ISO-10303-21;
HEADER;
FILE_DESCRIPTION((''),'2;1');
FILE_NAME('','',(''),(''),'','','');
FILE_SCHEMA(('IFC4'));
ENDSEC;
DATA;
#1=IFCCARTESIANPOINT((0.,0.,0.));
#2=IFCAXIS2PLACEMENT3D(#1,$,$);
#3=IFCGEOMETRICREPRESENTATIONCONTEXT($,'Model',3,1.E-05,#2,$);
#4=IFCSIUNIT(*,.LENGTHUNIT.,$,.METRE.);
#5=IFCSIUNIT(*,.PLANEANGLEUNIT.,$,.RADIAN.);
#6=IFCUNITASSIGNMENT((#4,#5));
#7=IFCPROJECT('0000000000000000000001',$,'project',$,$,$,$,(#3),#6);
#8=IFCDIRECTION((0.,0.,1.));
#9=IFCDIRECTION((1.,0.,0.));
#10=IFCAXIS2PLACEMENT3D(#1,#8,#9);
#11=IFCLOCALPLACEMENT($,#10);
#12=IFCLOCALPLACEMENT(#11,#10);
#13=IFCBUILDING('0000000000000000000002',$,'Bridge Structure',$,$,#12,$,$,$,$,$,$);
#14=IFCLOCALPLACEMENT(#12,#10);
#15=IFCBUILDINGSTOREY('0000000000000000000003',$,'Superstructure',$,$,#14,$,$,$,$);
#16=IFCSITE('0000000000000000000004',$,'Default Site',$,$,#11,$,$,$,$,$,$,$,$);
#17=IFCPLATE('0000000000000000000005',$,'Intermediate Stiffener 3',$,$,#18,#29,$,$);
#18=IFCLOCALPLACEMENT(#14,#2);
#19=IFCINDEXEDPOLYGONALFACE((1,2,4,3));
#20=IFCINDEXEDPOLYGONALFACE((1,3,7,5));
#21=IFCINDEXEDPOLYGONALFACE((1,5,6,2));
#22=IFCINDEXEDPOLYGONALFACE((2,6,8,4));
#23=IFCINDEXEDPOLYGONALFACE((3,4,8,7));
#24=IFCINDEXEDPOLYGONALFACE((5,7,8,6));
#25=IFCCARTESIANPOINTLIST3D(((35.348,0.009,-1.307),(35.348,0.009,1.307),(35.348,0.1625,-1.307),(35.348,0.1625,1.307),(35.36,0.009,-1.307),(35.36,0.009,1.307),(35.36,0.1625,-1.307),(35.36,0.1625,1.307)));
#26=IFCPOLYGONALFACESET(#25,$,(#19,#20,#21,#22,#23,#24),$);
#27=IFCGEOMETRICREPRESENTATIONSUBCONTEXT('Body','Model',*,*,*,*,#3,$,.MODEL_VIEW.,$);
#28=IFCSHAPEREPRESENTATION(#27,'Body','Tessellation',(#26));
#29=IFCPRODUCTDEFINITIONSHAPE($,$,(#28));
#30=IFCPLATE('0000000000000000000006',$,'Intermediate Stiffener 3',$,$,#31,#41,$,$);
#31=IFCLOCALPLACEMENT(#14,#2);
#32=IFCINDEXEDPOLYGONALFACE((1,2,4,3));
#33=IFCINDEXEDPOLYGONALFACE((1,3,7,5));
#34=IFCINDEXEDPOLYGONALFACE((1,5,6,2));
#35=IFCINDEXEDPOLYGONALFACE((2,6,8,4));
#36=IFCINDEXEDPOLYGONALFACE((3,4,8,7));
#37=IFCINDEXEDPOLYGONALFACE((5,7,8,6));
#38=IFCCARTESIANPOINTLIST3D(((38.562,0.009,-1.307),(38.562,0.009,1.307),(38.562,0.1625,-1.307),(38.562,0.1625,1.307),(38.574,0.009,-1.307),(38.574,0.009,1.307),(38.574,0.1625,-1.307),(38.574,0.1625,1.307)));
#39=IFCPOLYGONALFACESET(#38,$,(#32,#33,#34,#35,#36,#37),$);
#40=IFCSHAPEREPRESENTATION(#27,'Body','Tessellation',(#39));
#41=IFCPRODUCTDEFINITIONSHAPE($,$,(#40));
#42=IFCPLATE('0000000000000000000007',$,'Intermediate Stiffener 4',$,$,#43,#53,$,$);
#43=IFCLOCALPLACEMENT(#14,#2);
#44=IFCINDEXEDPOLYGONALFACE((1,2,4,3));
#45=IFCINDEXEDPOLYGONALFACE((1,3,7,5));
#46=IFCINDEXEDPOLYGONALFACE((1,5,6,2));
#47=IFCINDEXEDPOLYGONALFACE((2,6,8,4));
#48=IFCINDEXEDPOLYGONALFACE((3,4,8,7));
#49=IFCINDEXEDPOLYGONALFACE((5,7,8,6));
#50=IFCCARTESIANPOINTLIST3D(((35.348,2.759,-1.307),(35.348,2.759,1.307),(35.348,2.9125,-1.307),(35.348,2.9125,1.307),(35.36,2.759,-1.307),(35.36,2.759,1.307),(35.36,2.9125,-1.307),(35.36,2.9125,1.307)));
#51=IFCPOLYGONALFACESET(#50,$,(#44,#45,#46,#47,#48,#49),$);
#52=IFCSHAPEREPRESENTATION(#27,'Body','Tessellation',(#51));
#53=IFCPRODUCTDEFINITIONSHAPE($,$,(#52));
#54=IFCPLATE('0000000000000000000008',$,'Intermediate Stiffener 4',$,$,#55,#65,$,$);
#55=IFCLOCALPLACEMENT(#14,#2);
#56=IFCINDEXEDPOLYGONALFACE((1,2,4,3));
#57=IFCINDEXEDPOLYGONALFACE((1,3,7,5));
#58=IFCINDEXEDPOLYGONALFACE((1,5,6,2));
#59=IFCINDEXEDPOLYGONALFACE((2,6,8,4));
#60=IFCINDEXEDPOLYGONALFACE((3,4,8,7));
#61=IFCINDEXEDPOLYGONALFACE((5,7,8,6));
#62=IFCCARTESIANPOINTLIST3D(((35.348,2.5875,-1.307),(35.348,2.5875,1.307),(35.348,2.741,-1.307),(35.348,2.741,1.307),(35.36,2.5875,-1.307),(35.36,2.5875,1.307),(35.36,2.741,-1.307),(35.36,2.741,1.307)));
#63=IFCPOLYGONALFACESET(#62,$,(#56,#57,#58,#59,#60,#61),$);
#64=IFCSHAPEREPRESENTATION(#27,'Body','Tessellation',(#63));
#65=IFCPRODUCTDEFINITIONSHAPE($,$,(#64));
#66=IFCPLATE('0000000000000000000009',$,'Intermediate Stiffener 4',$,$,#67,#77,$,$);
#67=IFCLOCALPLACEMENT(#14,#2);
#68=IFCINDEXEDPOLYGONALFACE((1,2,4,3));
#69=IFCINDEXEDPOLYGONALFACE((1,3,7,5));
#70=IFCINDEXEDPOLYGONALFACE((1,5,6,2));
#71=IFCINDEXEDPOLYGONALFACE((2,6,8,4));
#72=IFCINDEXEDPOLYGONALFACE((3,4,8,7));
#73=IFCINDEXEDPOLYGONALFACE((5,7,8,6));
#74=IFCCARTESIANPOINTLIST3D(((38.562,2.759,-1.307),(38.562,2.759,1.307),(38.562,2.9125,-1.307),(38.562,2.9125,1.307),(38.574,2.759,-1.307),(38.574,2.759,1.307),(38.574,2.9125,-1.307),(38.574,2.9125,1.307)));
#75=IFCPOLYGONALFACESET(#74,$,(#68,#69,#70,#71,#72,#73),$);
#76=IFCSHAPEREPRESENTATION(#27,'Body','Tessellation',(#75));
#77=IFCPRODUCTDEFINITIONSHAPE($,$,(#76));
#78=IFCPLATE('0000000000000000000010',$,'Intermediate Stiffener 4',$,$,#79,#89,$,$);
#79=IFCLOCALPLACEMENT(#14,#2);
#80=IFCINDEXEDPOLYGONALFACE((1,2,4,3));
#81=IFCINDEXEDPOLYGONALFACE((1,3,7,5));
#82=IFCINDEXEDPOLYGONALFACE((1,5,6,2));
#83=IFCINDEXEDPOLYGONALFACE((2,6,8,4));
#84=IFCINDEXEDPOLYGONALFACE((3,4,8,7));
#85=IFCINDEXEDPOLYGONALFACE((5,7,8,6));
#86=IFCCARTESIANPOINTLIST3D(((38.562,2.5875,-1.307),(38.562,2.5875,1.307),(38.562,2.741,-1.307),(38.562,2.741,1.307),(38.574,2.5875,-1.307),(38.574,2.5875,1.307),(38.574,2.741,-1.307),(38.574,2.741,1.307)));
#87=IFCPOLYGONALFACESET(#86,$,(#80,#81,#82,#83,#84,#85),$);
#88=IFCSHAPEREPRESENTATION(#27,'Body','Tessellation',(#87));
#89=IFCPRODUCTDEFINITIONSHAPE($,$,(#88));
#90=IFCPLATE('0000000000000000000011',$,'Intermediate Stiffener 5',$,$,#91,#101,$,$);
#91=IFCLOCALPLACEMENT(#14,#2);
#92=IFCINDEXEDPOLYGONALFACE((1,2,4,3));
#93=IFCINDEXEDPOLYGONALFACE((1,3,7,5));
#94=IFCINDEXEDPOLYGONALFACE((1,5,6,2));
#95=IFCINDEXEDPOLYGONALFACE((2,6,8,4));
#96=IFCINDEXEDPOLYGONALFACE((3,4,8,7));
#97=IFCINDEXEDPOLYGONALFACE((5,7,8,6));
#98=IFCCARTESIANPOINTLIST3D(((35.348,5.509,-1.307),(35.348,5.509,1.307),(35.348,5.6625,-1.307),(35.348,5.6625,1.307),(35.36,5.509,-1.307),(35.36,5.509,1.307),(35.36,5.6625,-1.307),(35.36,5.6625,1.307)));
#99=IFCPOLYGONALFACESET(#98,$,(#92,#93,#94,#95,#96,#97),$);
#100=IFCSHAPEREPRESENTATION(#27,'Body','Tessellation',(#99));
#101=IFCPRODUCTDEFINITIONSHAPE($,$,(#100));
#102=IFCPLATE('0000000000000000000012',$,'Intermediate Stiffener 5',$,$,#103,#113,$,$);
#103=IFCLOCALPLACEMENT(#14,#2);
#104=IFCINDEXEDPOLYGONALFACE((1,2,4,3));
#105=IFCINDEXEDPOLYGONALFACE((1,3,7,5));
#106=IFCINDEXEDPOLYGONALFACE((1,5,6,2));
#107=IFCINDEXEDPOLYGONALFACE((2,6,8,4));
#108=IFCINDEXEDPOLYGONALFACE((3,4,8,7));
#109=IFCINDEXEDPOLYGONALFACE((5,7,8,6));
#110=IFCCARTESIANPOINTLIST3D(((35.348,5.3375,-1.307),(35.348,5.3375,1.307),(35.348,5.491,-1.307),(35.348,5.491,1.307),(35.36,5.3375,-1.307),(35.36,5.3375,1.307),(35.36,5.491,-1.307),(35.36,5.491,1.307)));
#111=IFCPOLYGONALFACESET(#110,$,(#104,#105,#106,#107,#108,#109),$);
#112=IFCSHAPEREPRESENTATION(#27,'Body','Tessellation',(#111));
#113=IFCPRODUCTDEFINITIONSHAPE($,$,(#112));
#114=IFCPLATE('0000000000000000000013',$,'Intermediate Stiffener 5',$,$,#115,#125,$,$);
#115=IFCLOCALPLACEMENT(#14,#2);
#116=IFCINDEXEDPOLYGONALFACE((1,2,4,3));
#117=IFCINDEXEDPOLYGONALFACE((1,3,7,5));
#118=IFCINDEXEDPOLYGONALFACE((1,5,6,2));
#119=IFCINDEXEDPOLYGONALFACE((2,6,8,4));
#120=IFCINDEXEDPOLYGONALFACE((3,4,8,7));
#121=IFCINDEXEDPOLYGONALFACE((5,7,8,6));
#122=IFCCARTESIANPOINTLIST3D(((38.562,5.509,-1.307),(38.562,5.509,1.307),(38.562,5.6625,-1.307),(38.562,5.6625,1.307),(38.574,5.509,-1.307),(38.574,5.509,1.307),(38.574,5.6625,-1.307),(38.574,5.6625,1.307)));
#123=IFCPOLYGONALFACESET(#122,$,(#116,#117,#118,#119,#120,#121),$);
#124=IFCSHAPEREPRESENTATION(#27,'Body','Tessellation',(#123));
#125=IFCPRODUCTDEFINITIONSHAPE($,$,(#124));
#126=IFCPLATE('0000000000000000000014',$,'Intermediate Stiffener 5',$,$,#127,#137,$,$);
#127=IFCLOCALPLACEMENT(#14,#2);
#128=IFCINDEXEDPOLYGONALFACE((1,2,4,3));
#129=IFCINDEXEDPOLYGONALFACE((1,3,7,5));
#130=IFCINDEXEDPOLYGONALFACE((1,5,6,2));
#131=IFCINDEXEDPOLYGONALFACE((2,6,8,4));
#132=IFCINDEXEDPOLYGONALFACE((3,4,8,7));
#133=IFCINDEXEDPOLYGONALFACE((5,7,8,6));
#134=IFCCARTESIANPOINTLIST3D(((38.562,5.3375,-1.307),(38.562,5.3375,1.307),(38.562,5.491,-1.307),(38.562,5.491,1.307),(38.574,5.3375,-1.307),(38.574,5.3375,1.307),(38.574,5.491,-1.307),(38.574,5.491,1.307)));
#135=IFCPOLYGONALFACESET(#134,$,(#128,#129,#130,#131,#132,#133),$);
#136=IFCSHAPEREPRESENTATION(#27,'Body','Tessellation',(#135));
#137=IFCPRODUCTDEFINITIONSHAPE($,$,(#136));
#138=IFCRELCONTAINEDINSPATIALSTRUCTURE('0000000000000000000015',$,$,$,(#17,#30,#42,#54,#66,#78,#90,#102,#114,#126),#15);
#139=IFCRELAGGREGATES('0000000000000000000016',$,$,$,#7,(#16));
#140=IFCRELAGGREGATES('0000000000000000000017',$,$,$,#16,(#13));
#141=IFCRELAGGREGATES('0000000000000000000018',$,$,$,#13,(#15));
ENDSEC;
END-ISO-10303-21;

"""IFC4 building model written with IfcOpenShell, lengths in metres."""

from ifc_helpers import new_model, si_unit, frame, origin, origin_with_axes, origin_2d_with_axis, place, context, subcontext, project, spatial, rectangle, extrude, element, save


model = new_model("IFC4")

# Units and contexts
model_context = context("Model", 3, precision=1e-05, world=origin())
body_context = subcontext(model_context, "Body", "Model", "MODEL_VIEW")
ifc_project = project(units=[si_unit("LENGTHUNIT", "METRE"), si_unit("PLANEANGLEUNIT", "RADIAN")], contexts=[model_context])

# Site, building, storey
site_placement = place(None, origin_with_axes())
site = spatial("IfcSite", under=ifc_project, at=site_placement, Name="Default Site")
building_placement = place(site_placement, origin_with_axes())
building = spatial("IfcBuilding", under=site, at=building_placement, Name="Bridge Structure")
storey_placement = place(building_placement, origin_with_axes())
storey = spatial("IfcBuildingStorey", under=building, at=storey_placement, Name="Superstructure")

# Plates
for number, where, z_axis, x_axis, name in (
    (1, (35.354, 0.0858, -1.307), (0.0, 0.0, 1.0), (1.0, 0.0, 0.0), "Intermediate Stiffener 3"),
    (2, (38.568, 0.0858, -1.307), (0.0, 0.0, 1.0), (1.0, 0.0, 0.0), "Intermediate Stiffener 3"),
    (3, (35.354, 2.8357, -1.307), (0.0, 0.0, 1.0), (1.0, 0.0, 0.0), "Intermediate Stiffener 4"),
    (4, (35.354, 2.6643, -1.307), (0.0, 0.0, 1.0), (1.0, 0.0, 0.0), "Intermediate Stiffener 4"),
    (5, (38.568, 2.8357, -1.307), (0.0, 0.0, 1.0), (1.0, 0.0, 0.0), "Intermediate Stiffener 4"),
    (6, (38.568, 2.6643, -1.307), (0.0, 0.0, 1.0), (1.0, 0.0, 0.0), "Intermediate Stiffener 4"),
    (7, (35.354, 5.5857, -1.307), (0.0, 0.0, 1.0), (1.0, 0.0, 0.0), "Intermediate Stiffener 5"),
    (8, (35.354, 5.4143, -1.307), (0.0, 0.0, 1.0), (1.0, 0.0, 0.0), "Intermediate Stiffener 5"),
    (9, (38.568, 5.5857, -1.307), (0.0, 0.0, 1.0), (1.0, 0.0, 0.0), "Intermediate Stiffener 5"),
    (10, (38.568, 5.4143, -1.307), (0.0, 0.0, 1.0), (1.0, 0.0, 0.0), "Intermediate Stiffener 5"),
):
    element("IfcPlate", number, at=place(storey_placement, frame(where, z_axis=z_axis, x_axis=x_axis)), inside=storey, Name=name, context=body_context, shape_type="SweptSolid", body=[
        extrude(rectangle(XDim=0.012, YDim=0.1535, at=origin_2d_with_axis()), origin_with_axes(), (0.0, 0.0, 1.0), 2.614),
    ])

save(model, "model.ifc")
